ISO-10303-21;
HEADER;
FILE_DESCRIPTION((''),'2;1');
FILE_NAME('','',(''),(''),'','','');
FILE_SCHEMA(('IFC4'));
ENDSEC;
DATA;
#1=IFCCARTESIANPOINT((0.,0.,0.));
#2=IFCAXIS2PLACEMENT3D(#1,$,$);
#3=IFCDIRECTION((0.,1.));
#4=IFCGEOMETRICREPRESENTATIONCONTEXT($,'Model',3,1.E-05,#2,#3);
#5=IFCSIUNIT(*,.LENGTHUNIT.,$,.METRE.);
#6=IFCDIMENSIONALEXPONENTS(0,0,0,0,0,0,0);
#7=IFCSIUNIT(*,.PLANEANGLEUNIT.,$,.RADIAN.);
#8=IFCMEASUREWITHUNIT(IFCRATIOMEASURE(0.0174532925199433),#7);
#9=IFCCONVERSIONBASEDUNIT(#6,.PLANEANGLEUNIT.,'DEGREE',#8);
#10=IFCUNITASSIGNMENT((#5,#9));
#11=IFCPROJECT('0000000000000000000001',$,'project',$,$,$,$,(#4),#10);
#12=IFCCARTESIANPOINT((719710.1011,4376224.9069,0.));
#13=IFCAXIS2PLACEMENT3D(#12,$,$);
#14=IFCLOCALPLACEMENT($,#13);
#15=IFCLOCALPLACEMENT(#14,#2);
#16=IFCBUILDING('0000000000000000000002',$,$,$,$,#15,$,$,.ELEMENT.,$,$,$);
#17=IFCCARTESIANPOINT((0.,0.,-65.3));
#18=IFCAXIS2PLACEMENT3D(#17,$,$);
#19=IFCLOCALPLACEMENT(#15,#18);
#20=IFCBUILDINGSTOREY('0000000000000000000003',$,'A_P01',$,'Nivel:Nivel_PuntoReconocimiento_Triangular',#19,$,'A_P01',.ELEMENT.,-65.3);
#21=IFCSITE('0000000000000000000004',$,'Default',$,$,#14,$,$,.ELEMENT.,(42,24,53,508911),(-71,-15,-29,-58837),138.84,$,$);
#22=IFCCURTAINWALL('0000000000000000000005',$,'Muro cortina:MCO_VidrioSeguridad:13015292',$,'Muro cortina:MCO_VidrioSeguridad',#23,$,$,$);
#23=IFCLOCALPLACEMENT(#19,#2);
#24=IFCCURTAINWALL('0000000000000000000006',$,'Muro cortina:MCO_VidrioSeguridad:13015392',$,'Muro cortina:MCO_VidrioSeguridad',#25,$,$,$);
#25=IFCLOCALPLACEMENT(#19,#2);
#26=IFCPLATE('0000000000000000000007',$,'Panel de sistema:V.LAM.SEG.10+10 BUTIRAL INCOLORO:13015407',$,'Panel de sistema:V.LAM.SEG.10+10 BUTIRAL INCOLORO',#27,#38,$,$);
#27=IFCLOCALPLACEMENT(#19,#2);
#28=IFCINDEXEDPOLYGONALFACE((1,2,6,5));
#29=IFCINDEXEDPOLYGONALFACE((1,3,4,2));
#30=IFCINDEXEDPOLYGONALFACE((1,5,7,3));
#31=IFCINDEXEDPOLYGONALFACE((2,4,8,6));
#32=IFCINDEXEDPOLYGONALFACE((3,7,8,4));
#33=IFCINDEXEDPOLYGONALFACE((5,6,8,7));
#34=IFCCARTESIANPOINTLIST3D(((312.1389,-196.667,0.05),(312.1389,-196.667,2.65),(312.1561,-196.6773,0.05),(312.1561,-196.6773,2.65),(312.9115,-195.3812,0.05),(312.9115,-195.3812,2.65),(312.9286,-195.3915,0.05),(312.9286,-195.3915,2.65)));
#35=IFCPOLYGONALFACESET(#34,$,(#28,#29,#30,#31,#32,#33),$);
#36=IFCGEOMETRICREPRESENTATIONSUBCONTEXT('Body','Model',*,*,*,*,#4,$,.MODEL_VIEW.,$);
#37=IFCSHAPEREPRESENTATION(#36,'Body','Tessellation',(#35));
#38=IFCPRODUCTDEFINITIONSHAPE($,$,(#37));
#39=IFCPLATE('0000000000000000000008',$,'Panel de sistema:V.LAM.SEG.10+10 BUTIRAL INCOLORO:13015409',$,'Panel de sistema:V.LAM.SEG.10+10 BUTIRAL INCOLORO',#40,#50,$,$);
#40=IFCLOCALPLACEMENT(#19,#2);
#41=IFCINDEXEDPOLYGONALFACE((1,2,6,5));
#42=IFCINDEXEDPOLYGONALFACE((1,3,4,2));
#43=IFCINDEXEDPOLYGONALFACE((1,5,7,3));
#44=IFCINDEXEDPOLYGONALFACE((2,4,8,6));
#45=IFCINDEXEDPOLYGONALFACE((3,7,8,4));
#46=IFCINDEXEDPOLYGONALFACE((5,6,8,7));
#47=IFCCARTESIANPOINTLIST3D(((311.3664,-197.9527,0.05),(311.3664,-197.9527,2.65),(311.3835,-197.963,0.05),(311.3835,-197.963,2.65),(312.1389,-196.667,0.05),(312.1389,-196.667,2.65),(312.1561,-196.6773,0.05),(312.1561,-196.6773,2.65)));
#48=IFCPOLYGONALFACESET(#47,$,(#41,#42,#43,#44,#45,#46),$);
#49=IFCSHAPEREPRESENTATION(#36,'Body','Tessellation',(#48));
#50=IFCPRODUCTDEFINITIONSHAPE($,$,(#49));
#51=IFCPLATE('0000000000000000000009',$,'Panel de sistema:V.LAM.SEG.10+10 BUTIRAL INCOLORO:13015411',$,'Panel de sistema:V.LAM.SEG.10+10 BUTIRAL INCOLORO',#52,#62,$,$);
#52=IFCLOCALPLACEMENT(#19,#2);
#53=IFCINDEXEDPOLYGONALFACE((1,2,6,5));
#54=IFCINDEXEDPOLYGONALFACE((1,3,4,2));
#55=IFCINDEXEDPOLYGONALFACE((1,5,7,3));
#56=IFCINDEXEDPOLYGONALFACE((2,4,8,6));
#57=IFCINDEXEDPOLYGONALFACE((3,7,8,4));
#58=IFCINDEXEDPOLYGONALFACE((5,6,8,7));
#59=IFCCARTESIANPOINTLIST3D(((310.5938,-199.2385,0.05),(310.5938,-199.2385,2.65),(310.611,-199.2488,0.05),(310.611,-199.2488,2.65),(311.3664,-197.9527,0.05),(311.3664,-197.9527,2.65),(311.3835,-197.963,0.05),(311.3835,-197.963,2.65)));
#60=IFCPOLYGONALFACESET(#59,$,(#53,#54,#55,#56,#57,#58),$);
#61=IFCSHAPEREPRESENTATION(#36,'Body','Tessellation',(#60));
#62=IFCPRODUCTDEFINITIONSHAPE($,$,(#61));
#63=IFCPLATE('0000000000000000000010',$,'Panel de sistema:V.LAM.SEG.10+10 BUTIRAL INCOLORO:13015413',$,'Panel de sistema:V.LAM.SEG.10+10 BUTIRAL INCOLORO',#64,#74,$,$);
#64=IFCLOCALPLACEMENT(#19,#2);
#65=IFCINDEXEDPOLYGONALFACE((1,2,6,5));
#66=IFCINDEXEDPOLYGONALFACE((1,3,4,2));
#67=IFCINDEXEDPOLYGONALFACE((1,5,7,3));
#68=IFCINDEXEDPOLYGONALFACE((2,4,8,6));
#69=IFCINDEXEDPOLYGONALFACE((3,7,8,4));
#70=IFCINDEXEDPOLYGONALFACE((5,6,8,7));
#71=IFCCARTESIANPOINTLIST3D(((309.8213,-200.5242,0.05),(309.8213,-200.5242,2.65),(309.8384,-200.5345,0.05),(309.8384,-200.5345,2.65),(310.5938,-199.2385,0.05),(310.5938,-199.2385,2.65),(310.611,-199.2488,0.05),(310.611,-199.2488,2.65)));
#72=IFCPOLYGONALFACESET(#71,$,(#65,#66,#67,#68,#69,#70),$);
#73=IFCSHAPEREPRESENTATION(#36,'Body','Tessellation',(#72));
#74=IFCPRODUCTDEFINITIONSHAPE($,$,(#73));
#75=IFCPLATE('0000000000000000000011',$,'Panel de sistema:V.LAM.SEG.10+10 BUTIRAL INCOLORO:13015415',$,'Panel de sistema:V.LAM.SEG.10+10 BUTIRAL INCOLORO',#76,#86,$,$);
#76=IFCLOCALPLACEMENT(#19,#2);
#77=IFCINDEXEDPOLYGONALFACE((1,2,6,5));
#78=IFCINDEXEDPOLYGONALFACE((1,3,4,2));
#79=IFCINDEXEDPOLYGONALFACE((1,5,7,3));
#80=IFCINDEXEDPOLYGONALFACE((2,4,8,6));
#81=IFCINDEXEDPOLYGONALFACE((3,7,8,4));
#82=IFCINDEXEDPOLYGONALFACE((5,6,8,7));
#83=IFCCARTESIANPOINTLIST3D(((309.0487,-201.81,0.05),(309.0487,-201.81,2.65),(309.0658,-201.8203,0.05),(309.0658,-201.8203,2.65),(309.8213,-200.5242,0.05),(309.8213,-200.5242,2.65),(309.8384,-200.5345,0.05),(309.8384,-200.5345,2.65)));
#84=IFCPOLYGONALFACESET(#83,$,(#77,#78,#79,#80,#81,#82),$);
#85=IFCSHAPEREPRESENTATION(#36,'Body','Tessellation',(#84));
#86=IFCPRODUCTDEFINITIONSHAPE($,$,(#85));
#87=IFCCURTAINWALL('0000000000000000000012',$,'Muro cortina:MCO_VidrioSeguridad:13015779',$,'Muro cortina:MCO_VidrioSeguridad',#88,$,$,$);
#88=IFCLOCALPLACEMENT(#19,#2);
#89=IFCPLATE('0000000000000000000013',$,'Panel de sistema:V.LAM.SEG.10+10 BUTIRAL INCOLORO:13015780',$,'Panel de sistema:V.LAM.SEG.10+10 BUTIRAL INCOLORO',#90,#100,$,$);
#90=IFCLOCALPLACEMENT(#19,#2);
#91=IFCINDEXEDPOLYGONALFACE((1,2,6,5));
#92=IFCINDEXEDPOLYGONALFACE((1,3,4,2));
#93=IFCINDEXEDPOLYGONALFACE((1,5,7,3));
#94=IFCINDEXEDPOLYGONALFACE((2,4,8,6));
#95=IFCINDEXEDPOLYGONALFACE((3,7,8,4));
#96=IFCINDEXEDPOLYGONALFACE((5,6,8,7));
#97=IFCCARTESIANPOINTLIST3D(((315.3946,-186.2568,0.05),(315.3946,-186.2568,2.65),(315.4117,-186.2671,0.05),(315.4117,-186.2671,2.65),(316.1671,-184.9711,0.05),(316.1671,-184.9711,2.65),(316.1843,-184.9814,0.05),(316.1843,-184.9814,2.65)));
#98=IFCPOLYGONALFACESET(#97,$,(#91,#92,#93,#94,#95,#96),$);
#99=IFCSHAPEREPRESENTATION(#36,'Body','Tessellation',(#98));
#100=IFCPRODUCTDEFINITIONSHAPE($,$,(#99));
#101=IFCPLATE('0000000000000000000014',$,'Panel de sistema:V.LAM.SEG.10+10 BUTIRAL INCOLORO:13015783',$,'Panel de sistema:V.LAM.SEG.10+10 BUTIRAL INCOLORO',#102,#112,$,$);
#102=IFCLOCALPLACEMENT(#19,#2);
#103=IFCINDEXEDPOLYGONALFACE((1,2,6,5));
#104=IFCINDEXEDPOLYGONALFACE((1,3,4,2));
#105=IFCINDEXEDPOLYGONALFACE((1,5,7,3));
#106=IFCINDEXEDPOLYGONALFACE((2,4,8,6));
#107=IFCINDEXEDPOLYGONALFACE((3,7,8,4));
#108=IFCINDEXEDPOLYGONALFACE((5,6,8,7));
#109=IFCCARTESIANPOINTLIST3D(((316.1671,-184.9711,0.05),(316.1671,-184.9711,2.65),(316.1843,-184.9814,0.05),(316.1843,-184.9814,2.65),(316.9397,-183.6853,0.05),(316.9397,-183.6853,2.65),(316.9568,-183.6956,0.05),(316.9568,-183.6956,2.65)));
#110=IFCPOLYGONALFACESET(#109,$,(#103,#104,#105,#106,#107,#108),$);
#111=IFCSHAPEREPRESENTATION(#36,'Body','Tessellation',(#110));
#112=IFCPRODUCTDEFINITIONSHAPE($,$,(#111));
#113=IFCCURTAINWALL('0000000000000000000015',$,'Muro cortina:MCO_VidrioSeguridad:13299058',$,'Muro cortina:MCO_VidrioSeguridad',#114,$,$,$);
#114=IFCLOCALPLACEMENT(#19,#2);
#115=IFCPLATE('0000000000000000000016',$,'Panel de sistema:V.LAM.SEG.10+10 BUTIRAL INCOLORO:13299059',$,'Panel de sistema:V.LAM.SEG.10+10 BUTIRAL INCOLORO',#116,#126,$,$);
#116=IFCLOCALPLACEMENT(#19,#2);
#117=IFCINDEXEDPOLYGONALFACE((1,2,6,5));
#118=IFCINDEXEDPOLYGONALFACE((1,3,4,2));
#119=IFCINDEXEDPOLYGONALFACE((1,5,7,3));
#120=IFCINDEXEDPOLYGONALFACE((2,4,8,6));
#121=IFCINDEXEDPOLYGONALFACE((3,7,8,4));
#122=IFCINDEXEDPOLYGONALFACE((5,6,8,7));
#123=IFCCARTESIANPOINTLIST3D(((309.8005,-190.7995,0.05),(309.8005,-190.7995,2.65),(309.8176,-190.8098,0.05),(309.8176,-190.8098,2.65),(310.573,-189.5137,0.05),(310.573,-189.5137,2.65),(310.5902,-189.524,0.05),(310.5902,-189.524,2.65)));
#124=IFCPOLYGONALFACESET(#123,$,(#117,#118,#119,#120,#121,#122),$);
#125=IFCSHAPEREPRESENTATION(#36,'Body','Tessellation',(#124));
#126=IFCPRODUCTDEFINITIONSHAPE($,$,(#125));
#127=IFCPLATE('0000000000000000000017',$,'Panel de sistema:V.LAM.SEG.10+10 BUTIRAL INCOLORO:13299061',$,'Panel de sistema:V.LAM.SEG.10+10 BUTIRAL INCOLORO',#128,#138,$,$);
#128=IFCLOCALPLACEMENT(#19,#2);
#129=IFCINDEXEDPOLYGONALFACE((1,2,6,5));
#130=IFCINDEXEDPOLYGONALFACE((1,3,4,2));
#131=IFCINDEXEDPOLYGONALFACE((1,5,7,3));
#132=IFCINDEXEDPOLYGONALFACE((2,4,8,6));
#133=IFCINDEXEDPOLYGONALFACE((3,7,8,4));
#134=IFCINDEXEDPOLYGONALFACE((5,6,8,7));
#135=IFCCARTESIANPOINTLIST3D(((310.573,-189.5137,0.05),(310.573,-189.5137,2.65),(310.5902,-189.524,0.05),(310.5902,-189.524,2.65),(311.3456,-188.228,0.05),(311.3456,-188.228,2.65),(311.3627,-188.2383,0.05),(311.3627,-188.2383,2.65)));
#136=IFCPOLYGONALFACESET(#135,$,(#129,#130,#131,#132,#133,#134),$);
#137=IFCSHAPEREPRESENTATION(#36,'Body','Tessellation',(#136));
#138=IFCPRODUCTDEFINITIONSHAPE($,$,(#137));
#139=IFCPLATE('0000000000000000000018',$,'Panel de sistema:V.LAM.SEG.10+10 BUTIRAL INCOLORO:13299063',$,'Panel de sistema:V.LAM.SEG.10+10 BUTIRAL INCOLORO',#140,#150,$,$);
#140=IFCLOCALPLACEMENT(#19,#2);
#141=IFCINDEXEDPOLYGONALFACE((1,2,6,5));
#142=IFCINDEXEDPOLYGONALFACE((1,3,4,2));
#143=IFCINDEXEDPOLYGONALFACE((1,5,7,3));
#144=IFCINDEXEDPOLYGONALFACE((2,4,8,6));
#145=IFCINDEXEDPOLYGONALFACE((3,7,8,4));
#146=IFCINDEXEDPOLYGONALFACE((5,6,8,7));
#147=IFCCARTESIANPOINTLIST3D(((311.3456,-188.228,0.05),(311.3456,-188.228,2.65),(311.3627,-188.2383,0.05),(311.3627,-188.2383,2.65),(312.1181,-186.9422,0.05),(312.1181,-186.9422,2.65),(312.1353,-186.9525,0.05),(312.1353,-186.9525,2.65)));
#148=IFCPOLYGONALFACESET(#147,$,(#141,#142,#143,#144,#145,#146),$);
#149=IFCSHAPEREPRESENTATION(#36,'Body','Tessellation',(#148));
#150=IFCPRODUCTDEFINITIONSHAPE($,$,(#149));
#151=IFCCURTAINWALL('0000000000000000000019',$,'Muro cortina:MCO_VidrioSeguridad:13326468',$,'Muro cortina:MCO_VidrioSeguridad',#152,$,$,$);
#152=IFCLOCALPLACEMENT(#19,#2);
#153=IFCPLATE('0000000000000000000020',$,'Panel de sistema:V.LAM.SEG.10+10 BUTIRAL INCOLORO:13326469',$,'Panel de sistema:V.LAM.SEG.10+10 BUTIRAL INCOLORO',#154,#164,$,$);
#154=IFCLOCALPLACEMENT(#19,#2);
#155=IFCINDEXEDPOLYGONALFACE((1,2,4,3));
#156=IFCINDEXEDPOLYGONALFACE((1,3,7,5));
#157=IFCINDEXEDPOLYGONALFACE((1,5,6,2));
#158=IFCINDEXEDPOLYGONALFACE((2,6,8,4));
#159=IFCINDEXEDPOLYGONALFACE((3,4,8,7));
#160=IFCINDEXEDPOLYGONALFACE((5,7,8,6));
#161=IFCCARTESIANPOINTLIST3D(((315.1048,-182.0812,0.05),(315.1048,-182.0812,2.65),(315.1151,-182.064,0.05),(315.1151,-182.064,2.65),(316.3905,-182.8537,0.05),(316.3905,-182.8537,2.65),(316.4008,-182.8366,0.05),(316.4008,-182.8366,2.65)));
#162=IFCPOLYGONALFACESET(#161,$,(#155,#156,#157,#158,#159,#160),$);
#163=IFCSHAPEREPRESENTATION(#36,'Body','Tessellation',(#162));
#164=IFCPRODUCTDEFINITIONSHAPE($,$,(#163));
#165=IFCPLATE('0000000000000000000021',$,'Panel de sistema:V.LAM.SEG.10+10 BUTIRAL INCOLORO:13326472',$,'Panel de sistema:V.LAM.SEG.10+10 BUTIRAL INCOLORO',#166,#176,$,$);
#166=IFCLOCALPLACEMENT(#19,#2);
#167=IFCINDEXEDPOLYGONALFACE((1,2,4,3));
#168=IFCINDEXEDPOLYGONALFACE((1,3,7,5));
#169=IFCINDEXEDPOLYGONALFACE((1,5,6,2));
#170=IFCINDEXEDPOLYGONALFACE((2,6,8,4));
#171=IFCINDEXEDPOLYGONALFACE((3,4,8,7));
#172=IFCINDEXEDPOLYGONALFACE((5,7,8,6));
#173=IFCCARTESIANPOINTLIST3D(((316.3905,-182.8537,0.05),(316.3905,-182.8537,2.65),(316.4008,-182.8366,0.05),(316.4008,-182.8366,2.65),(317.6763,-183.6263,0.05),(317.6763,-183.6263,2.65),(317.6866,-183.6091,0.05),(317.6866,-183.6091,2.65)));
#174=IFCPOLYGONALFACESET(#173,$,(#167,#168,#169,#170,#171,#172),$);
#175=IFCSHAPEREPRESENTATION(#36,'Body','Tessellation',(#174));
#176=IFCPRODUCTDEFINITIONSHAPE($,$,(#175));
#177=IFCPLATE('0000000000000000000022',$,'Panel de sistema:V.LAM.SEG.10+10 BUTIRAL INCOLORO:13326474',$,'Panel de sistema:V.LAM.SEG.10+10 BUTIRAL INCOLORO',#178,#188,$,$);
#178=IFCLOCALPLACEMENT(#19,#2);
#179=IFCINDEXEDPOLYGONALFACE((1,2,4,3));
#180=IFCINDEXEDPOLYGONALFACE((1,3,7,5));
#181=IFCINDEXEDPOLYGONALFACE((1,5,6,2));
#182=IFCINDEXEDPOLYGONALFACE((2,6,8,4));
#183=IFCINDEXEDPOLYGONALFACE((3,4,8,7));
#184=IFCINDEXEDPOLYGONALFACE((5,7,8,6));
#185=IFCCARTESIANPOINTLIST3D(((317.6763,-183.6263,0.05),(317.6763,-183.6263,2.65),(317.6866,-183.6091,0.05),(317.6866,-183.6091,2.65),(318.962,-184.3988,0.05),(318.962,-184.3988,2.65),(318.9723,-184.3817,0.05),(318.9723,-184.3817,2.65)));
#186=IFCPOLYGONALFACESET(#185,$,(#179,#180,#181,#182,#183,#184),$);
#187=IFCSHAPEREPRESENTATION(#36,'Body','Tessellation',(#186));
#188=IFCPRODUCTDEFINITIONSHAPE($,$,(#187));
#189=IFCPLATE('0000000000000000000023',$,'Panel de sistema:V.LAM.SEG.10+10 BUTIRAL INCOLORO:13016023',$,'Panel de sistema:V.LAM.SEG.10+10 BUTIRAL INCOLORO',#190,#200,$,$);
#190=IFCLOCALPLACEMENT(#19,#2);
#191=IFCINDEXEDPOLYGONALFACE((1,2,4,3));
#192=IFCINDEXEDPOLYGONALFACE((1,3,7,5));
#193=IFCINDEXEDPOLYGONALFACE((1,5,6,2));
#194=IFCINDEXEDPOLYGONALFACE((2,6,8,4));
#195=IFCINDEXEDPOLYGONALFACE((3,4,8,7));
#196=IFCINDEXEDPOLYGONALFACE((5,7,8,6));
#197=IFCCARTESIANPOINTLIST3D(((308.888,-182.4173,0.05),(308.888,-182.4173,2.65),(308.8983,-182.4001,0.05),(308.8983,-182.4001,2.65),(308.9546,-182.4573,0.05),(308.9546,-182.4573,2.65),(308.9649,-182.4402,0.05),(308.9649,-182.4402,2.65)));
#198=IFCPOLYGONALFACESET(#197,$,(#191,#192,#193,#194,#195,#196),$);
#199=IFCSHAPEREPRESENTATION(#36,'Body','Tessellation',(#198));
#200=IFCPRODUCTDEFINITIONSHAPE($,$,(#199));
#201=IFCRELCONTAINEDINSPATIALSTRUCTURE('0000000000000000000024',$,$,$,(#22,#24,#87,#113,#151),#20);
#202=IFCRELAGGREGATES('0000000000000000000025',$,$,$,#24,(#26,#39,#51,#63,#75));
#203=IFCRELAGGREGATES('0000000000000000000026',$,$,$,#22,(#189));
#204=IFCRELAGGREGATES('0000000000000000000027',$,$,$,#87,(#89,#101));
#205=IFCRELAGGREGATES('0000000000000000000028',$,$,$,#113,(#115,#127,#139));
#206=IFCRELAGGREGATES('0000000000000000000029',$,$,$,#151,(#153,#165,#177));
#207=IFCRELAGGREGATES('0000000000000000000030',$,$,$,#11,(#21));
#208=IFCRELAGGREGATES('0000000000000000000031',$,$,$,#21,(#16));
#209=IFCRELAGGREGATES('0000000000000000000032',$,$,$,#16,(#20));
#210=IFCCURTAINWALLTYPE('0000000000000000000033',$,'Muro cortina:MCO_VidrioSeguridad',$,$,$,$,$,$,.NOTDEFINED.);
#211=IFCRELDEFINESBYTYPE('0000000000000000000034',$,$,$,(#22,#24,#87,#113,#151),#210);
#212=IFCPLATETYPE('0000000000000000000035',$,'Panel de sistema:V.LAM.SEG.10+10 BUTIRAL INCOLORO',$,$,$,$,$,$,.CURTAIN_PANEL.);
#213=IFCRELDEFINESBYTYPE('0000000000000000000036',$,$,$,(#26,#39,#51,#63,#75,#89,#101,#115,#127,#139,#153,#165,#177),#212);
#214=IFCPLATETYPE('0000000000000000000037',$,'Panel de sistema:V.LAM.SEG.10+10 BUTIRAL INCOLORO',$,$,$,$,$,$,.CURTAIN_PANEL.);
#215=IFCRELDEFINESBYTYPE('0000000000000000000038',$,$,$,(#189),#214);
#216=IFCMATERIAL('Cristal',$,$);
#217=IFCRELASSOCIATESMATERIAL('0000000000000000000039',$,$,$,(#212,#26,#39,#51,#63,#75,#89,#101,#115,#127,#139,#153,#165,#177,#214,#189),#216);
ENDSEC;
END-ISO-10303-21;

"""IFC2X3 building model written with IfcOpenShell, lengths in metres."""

from ifc_helpers import new_model, entity, si_unit, converted_unit, direction, frame, origin, origin_2d_with_axis, place, context, subcontext, project, spatial, rectangle, extrude, source, transform, mapped, material, type_object, type_shapes, element, aggregate, save


model = new_model("IFC2X3")

# Units and contexts
model_context = context("Model", 3, precision=1e-05, world=origin(), true_north=direction((0.0, 1.0)))
body_context = subcontext(model_context, "Body", "Model", "MODEL_VIEW")
ifc_project = project(units=[si_unit("LENGTHUNIT", "METRE"), converted_unit("PLANEANGLEUNIT", "DEGREE", entity("IfcRatioMeasure", 0.0174532925199433), si_unit("PLANEANGLEUNIT", "RADIAN"), dimensions=[0, 0, 0, 0, 0, 0, 0])], contexts=[model_context])

# Site, building, storey
site_placement = place(None, frame((719710.1011, 4376224.9069, 0.0)))
site = spatial("IfcSite", under=ifc_project, at=site_placement, Name="Default", CompositionType="ELEMENT", RefLatitude=(42, 24, 53, 508911), RefLongitude=(-71, -15, -29, -58837), RefElevation=138.84)
building_placement = place(site_placement, origin())
building = spatial("IfcBuilding", under=site, at=building_placement, CompositionType="ELEMENT")
storey_placement = place(building_placement, frame((0.0, 0.0, -65.3)))
storey = spatial("IfcBuildingStorey", under=building, at=storey_placement, Name="A_P01", ObjectType="Nivel:Nivel_PuntoReconocimiento_Triangular", LongName="A_P01", CompositionType="ELEMENT", Elevation=-65.3)

# Curtain walls, plates
curtain_wall_type = type_object("IfcCurtainWallType", Name="Muro cortina:MCO_VidrioSeguridad", PredefinedType="NOTDEFINED")
curtain_wall_1_placement = place(storey_placement, frame((0.0, 0.0, 65.3)))
curtain_wall_1 = element("IfcCurtainWall", 1, at=curtain_wall_1_placement, inside=storey, type_object=curtain_wall_type, Name="Muro cortina:MCO_VidrioSeguridad:13015292", ObjectType="Muro cortina:MCO_VidrioSeguridad")
ifc_material = material(Name="Cristal")
plate_type_1 = type_object("IfcPlateType", Name="Panel de sistema:V.LAM.SEG.10+10 BUTIRAL INCOLORO", PredefinedType="CURTAIN_PANEL", material=ifc_material)
shared_shape_1 = source(origin(), body_context, "Body", "SweptSolid", [
    extrude(rectangle(XDim=0.02, YDim=1.5, at=origin_2d_with_axis()), frame((0.0, 0.0, 0.0), z_axis=(0.0, 0.0, 1.0), x_axis=(0.0, 1.0, 0.0)), (0.0, 0.0, 1.0), 2.6),
])
type_shapes(plate_type_1, [shared_shape_1])
curtain_wall_2_placement = place(storey_placement, frame((0.0, 0.0, 65.3)))
curtain_wall_2 = element("IfcCurtainWall", 2, at=curtain_wall_2_placement, inside=storey, type_object=curtain_wall_type, Name="Muro cortina:MCO_VidrioSeguridad:13015392", ObjectType="Muro cortina:MCO_VidrioSeguridad")
plate_1_placement = place(curtain_wall_2_placement, frame((312.5338, -196.0292, -65.25), z_axis=(0.0, 0.0, 1.0), x_axis=(-0.515038, -0.857167, 0.0)))
plate_1 = element("IfcPlate", 3, at=plate_1_placement, type_object=plate_type_1, material=ifc_material, Name="Panel de sistema:V.LAM.SEG.10+10 BUTIRAL INCOLORO:13015407", ObjectType="Panel de sistema:V.LAM.SEG.10+10 BUTIRAL INCOLORO", context=body_context, shape_type="MappedRepresentation", body=[
    mapped(shared_shape_1, transform((0.0, 0.0, 0.0), scale=1.0)),
])
plate_2_placement = place(curtain_wall_2_placement, frame((311.7612, -197.315, -65.25), z_axis=(0.0, 0.0, 1.0), x_axis=(-0.515038, -0.857167, 0.0)))
plate_2 = element("IfcPlate", 4, at=plate_2_placement, type_object=plate_type_1, material=ifc_material, Name="Panel de sistema:V.LAM.SEG.10+10 BUTIRAL INCOLORO:13015409", ObjectType="Panel de sistema:V.LAM.SEG.10+10 BUTIRAL INCOLORO", context=body_context, shape_type="MappedRepresentation", body=[
    mapped(shared_shape_1, transform((0.0, 0.0, 0.0), scale=1.0)),
])
plate_3_placement = place(curtain_wall_2_placement, frame((310.9887, -198.6007, -65.25), z_axis=(0.0, 0.0, 1.0), x_axis=(-0.515038, -0.857167, 0.0)))
plate_3 = element("IfcPlate", 5, at=plate_3_placement, type_object=plate_type_1, material=ifc_material, Name="Panel de sistema:V.LAM.SEG.10+10 BUTIRAL INCOLORO:13015411", ObjectType="Panel de sistema:V.LAM.SEG.10+10 BUTIRAL INCOLORO", context=body_context, shape_type="MappedRepresentation", body=[
    mapped(shared_shape_1, transform((0.0, 0.0, 0.0), scale=1.0)),
])
plate_4_placement = place(curtain_wall_2_placement, frame((310.2161, -199.8865, -65.25), z_axis=(0.0, 0.0, 1.0), x_axis=(-0.515038, -0.857167, 0.0)))
plate_4 = element("IfcPlate", 6, at=plate_4_placement, type_object=plate_type_1, material=ifc_material, Name="Panel de sistema:V.LAM.SEG.10+10 BUTIRAL INCOLORO:13015413", ObjectType="Panel de sistema:V.LAM.SEG.10+10 BUTIRAL INCOLORO", context=body_context, shape_type="MappedRepresentation", body=[
    mapped(shared_shape_1, transform((0.0, 0.0, 0.0), scale=1.0)),
])
plate_5_placement = place(curtain_wall_2_placement, frame((309.4435, -201.1722, -65.25), z_axis=(0.0, 0.0, 1.0), x_axis=(-0.515038, -0.857167, 0.0)))
plate_5 = element("IfcPlate", 7, at=plate_5_placement, type_object=plate_type_1, material=ifc_material, Name="Panel de sistema:V.LAM.SEG.10+10 BUTIRAL INCOLORO:13015415", ObjectType="Panel de sistema:V.LAM.SEG.10+10 BUTIRAL INCOLORO", context=body_context, shape_type="MappedRepresentation", body=[
    mapped(shared_shape_1, transform((0.0, 0.0, 0.0), scale=1.0)),
])
aggregate(curtain_wall_2, [plate_1, plate_2, plate_3, plate_4, plate_5])
curtain_wall_3_placement = place(storey_placement, frame((0.0, 0.0, 65.3)))
curtain_wall_3 = element("IfcCurtainWall", 8, at=curtain_wall_3_placement, inside=storey, type_object=curtain_wall_type, Name="Muro cortina:MCO_VidrioSeguridad:13015779", ObjectType="Muro cortina:MCO_VidrioSeguridad")
plate_6_placement = place(curtain_wall_3_placement, frame((315.7894, -185.6191, -65.25), z_axis=(0.0, 0.0, 1.0), x_axis=(0.515038, 0.857167, 0.0)))
plate_6 = element("IfcPlate", 9, at=plate_6_placement, type_object=plate_type_1, material=ifc_material, Name="Panel de sistema:V.LAM.SEG.10+10 BUTIRAL INCOLORO:13015780", ObjectType="Panel de sistema:V.LAM.SEG.10+10 BUTIRAL INCOLORO", context=body_context, shape_type="MappedRepresentation", body=[
    mapped(shared_shape_1, transform((0.0, 0.0, 0.0), scale=1.0)),
])
plate_7_placement = place(curtain_wall_3_placement, frame((316.562, -184.3333, -65.25), z_axis=(0.0, 0.0, 1.0), x_axis=(0.515038, 0.857167, 0.0)))
plate_7 = element("IfcPlate", 10, at=plate_7_placement, type_object=plate_type_1, material=ifc_material, Name="Panel de sistema:V.LAM.SEG.10+10 BUTIRAL INCOLORO:13015783", ObjectType="Panel de sistema:V.LAM.SEG.10+10 BUTIRAL INCOLORO", context=body_context, shape_type="MappedRepresentation", body=[
    mapped(shared_shape_1, transform((0.0, 0.0, 0.0), scale=1.0)),
])
curtain_wall_4_placement = place(storey_placement, frame((0.0, 0.0, 65.3)))
curtain_wall_4 = element("IfcCurtainWall", 11, at=curtain_wall_4_placement, inside=storey, type_object=curtain_wall_type, Name="Muro cortina:MCO_VidrioSeguridad:13299058", ObjectType="Muro cortina:MCO_VidrioSeguridad")
plate_8_placement = place(curtain_wall_4_placement, frame((310.1953, -190.1618, -65.25), z_axis=(0.0, 0.0, 1.0), x_axis=(0.515038, 0.857167, 0.0)))
plate_8 = element("IfcPlate", 12, at=plate_8_placement, type_object=plate_type_1, material=ifc_material, Name="Panel de sistema:V.LAM.SEG.10+10 BUTIRAL INCOLORO:13299059", ObjectType="Panel de sistema:V.LAM.SEG.10+10 BUTIRAL INCOLORO", context=body_context, shape_type="MappedRepresentation", body=[
    mapped(shared_shape_1, transform((0.0, 0.0, 0.0), scale=1.0)),
])
plate_9_placement = place(curtain_wall_4_placement, frame((310.9679, -188.876, -65.25), z_axis=(0.0, 0.0, 1.0), x_axis=(0.515038, 0.857167, 0.0)))
plate_9 = element("IfcPlate", 13, at=plate_9_placement, type_object=plate_type_1, material=ifc_material, Name="Panel de sistema:V.LAM.SEG.10+10 BUTIRAL INCOLORO:13299061", ObjectType="Panel de sistema:V.LAM.SEG.10+10 BUTIRAL INCOLORO", context=body_context, shape_type="MappedRepresentation", body=[
    mapped(shared_shape_1, transform((0.0, 0.0, 0.0), scale=1.0)),
])
plate_10_placement = place(curtain_wall_4_placement, frame((311.7404, -187.5903, -65.25), z_axis=(0.0, 0.0, 1.0), x_axis=(0.515038, 0.857167, 0.0)))
plate_10 = element("IfcPlate", 14, at=plate_10_placement, type_object=plate_type_1, material=ifc_material, Name="Panel de sistema:V.LAM.SEG.10+10 BUTIRAL INCOLORO:13299063", ObjectType="Panel de sistema:V.LAM.SEG.10+10 BUTIRAL INCOLORO", context=body_context, shape_type="MappedRepresentation", body=[
    mapped(shared_shape_1, transform((0.0, 0.0, 0.0), scale=1.0)),
])
curtain_wall_5_placement = place(storey_placement, frame((0.0, 0.0, 65.3)))
curtain_wall_5 = element("IfcCurtainWall", 15, at=curtain_wall_5_placement, inside=storey, type_object=curtain_wall_type, Name="Muro cortina:MCO_VidrioSeguridad:13326468", ObjectType="Muro cortina:MCO_VidrioSeguridad")
plate_11_placement = place(curtain_wall_5_placement, frame((315.7528, -182.4589, -65.25), z_axis=(0.0, 0.0, 1.0), x_axis=(0.857167, -0.515038, 0.0)))
plate_11 = element("IfcPlate", 16, at=plate_11_placement, type_object=plate_type_1, material=ifc_material, Name="Panel de sistema:V.LAM.SEG.10+10 BUTIRAL INCOLORO:13326469", ObjectType="Panel de sistema:V.LAM.SEG.10+10 BUTIRAL INCOLORO", context=body_context, shape_type="MappedRepresentation", body=[
    mapped(shared_shape_1, transform((0.0, 0.0, 0.0), scale=1.0)),
])
plate_12_placement = place(curtain_wall_5_placement, frame((317.0386, -183.2314, -65.25), z_axis=(0.0, 0.0, 1.0), x_axis=(0.857167, -0.515038, 0.0)))
plate_12 = element("IfcPlate", 17, at=plate_12_placement, type_object=plate_type_1, material=ifc_material, Name="Panel de sistema:V.LAM.SEG.10+10 BUTIRAL INCOLORO:13326472", ObjectType="Panel de sistema:V.LAM.SEG.10+10 BUTIRAL INCOLORO", context=body_context, shape_type="MappedRepresentation", body=[
    mapped(shared_shape_1, transform((0.0, 0.0, 0.0), scale=1.0)),
])
plate_13_placement = place(curtain_wall_5_placement, frame((318.3243, -184.004, -65.25), z_axis=(0.0, 0.0, 1.0), x_axis=(0.857167, -0.515038, 0.0)))
plate_13 = element("IfcPlate", 18, at=plate_13_placement, type_object=plate_type_1, material=ifc_material, Name="Panel de sistema:V.LAM.SEG.10+10 BUTIRAL INCOLORO:13326474", ObjectType="Panel de sistema:V.LAM.SEG.10+10 BUTIRAL INCOLORO", context=body_context, shape_type="MappedRepresentation", body=[
    mapped(shared_shape_1, transform((0.0, 0.0, 0.0), scale=1.0)),
])

# Plate
plate_type_2 = type_object("IfcPlateType", Name="Panel de sistema:V.LAM.SEG.10+10 BUTIRAL INCOLORO", PredefinedType="CURTAIN_PANEL", material=ifc_material)
shared_shape_2 = source(origin(), body_context, "Body", "SweptSolid", [
    extrude(rectangle(XDim=0.02, YDim=0.0778, at=origin_2d_with_axis()), frame((0.0, 0.0, 0.0), z_axis=(0.0, 0.0, 1.0), x_axis=(0.0, 1.0, 0.0)), (0.0, 0.0, 1.0), 2.6),
])
type_shapes(plate_type_2, [shared_shape_2])
plate_14_placement = place(curtain_wall_1_placement, frame((308.9264, -182.4287, -65.25), z_axis=(0.0, 0.0, 1.0), x_axis=(-0.857167, 0.515038, 0.0)))
plate_14 = element("IfcPlate", 19, at=plate_14_placement, type_object=plate_type_2, material=ifc_material, Name="Panel de sistema:V.LAM.SEG.10+10 BUTIRAL INCOLORO:13016023", ObjectType="Panel de sistema:V.LAM.SEG.10+10 BUTIRAL INCOLORO", context=body_context, shape_type="MappedRepresentation", body=[
    mapped(shared_shape_2, transform((0.0, 0.0, 0.0), scale=1.0)),
])
aggregate(curtain_wall_1, [plate_14])
aggregate(curtain_wall_3, [plate_6, plate_7])

aggregate(curtain_wall_4, [plate_8, plate_9, plate_10])

aggregate(curtain_wall_5, [plate_11, plate_12, plate_13])

save(model, "model.ifc")
